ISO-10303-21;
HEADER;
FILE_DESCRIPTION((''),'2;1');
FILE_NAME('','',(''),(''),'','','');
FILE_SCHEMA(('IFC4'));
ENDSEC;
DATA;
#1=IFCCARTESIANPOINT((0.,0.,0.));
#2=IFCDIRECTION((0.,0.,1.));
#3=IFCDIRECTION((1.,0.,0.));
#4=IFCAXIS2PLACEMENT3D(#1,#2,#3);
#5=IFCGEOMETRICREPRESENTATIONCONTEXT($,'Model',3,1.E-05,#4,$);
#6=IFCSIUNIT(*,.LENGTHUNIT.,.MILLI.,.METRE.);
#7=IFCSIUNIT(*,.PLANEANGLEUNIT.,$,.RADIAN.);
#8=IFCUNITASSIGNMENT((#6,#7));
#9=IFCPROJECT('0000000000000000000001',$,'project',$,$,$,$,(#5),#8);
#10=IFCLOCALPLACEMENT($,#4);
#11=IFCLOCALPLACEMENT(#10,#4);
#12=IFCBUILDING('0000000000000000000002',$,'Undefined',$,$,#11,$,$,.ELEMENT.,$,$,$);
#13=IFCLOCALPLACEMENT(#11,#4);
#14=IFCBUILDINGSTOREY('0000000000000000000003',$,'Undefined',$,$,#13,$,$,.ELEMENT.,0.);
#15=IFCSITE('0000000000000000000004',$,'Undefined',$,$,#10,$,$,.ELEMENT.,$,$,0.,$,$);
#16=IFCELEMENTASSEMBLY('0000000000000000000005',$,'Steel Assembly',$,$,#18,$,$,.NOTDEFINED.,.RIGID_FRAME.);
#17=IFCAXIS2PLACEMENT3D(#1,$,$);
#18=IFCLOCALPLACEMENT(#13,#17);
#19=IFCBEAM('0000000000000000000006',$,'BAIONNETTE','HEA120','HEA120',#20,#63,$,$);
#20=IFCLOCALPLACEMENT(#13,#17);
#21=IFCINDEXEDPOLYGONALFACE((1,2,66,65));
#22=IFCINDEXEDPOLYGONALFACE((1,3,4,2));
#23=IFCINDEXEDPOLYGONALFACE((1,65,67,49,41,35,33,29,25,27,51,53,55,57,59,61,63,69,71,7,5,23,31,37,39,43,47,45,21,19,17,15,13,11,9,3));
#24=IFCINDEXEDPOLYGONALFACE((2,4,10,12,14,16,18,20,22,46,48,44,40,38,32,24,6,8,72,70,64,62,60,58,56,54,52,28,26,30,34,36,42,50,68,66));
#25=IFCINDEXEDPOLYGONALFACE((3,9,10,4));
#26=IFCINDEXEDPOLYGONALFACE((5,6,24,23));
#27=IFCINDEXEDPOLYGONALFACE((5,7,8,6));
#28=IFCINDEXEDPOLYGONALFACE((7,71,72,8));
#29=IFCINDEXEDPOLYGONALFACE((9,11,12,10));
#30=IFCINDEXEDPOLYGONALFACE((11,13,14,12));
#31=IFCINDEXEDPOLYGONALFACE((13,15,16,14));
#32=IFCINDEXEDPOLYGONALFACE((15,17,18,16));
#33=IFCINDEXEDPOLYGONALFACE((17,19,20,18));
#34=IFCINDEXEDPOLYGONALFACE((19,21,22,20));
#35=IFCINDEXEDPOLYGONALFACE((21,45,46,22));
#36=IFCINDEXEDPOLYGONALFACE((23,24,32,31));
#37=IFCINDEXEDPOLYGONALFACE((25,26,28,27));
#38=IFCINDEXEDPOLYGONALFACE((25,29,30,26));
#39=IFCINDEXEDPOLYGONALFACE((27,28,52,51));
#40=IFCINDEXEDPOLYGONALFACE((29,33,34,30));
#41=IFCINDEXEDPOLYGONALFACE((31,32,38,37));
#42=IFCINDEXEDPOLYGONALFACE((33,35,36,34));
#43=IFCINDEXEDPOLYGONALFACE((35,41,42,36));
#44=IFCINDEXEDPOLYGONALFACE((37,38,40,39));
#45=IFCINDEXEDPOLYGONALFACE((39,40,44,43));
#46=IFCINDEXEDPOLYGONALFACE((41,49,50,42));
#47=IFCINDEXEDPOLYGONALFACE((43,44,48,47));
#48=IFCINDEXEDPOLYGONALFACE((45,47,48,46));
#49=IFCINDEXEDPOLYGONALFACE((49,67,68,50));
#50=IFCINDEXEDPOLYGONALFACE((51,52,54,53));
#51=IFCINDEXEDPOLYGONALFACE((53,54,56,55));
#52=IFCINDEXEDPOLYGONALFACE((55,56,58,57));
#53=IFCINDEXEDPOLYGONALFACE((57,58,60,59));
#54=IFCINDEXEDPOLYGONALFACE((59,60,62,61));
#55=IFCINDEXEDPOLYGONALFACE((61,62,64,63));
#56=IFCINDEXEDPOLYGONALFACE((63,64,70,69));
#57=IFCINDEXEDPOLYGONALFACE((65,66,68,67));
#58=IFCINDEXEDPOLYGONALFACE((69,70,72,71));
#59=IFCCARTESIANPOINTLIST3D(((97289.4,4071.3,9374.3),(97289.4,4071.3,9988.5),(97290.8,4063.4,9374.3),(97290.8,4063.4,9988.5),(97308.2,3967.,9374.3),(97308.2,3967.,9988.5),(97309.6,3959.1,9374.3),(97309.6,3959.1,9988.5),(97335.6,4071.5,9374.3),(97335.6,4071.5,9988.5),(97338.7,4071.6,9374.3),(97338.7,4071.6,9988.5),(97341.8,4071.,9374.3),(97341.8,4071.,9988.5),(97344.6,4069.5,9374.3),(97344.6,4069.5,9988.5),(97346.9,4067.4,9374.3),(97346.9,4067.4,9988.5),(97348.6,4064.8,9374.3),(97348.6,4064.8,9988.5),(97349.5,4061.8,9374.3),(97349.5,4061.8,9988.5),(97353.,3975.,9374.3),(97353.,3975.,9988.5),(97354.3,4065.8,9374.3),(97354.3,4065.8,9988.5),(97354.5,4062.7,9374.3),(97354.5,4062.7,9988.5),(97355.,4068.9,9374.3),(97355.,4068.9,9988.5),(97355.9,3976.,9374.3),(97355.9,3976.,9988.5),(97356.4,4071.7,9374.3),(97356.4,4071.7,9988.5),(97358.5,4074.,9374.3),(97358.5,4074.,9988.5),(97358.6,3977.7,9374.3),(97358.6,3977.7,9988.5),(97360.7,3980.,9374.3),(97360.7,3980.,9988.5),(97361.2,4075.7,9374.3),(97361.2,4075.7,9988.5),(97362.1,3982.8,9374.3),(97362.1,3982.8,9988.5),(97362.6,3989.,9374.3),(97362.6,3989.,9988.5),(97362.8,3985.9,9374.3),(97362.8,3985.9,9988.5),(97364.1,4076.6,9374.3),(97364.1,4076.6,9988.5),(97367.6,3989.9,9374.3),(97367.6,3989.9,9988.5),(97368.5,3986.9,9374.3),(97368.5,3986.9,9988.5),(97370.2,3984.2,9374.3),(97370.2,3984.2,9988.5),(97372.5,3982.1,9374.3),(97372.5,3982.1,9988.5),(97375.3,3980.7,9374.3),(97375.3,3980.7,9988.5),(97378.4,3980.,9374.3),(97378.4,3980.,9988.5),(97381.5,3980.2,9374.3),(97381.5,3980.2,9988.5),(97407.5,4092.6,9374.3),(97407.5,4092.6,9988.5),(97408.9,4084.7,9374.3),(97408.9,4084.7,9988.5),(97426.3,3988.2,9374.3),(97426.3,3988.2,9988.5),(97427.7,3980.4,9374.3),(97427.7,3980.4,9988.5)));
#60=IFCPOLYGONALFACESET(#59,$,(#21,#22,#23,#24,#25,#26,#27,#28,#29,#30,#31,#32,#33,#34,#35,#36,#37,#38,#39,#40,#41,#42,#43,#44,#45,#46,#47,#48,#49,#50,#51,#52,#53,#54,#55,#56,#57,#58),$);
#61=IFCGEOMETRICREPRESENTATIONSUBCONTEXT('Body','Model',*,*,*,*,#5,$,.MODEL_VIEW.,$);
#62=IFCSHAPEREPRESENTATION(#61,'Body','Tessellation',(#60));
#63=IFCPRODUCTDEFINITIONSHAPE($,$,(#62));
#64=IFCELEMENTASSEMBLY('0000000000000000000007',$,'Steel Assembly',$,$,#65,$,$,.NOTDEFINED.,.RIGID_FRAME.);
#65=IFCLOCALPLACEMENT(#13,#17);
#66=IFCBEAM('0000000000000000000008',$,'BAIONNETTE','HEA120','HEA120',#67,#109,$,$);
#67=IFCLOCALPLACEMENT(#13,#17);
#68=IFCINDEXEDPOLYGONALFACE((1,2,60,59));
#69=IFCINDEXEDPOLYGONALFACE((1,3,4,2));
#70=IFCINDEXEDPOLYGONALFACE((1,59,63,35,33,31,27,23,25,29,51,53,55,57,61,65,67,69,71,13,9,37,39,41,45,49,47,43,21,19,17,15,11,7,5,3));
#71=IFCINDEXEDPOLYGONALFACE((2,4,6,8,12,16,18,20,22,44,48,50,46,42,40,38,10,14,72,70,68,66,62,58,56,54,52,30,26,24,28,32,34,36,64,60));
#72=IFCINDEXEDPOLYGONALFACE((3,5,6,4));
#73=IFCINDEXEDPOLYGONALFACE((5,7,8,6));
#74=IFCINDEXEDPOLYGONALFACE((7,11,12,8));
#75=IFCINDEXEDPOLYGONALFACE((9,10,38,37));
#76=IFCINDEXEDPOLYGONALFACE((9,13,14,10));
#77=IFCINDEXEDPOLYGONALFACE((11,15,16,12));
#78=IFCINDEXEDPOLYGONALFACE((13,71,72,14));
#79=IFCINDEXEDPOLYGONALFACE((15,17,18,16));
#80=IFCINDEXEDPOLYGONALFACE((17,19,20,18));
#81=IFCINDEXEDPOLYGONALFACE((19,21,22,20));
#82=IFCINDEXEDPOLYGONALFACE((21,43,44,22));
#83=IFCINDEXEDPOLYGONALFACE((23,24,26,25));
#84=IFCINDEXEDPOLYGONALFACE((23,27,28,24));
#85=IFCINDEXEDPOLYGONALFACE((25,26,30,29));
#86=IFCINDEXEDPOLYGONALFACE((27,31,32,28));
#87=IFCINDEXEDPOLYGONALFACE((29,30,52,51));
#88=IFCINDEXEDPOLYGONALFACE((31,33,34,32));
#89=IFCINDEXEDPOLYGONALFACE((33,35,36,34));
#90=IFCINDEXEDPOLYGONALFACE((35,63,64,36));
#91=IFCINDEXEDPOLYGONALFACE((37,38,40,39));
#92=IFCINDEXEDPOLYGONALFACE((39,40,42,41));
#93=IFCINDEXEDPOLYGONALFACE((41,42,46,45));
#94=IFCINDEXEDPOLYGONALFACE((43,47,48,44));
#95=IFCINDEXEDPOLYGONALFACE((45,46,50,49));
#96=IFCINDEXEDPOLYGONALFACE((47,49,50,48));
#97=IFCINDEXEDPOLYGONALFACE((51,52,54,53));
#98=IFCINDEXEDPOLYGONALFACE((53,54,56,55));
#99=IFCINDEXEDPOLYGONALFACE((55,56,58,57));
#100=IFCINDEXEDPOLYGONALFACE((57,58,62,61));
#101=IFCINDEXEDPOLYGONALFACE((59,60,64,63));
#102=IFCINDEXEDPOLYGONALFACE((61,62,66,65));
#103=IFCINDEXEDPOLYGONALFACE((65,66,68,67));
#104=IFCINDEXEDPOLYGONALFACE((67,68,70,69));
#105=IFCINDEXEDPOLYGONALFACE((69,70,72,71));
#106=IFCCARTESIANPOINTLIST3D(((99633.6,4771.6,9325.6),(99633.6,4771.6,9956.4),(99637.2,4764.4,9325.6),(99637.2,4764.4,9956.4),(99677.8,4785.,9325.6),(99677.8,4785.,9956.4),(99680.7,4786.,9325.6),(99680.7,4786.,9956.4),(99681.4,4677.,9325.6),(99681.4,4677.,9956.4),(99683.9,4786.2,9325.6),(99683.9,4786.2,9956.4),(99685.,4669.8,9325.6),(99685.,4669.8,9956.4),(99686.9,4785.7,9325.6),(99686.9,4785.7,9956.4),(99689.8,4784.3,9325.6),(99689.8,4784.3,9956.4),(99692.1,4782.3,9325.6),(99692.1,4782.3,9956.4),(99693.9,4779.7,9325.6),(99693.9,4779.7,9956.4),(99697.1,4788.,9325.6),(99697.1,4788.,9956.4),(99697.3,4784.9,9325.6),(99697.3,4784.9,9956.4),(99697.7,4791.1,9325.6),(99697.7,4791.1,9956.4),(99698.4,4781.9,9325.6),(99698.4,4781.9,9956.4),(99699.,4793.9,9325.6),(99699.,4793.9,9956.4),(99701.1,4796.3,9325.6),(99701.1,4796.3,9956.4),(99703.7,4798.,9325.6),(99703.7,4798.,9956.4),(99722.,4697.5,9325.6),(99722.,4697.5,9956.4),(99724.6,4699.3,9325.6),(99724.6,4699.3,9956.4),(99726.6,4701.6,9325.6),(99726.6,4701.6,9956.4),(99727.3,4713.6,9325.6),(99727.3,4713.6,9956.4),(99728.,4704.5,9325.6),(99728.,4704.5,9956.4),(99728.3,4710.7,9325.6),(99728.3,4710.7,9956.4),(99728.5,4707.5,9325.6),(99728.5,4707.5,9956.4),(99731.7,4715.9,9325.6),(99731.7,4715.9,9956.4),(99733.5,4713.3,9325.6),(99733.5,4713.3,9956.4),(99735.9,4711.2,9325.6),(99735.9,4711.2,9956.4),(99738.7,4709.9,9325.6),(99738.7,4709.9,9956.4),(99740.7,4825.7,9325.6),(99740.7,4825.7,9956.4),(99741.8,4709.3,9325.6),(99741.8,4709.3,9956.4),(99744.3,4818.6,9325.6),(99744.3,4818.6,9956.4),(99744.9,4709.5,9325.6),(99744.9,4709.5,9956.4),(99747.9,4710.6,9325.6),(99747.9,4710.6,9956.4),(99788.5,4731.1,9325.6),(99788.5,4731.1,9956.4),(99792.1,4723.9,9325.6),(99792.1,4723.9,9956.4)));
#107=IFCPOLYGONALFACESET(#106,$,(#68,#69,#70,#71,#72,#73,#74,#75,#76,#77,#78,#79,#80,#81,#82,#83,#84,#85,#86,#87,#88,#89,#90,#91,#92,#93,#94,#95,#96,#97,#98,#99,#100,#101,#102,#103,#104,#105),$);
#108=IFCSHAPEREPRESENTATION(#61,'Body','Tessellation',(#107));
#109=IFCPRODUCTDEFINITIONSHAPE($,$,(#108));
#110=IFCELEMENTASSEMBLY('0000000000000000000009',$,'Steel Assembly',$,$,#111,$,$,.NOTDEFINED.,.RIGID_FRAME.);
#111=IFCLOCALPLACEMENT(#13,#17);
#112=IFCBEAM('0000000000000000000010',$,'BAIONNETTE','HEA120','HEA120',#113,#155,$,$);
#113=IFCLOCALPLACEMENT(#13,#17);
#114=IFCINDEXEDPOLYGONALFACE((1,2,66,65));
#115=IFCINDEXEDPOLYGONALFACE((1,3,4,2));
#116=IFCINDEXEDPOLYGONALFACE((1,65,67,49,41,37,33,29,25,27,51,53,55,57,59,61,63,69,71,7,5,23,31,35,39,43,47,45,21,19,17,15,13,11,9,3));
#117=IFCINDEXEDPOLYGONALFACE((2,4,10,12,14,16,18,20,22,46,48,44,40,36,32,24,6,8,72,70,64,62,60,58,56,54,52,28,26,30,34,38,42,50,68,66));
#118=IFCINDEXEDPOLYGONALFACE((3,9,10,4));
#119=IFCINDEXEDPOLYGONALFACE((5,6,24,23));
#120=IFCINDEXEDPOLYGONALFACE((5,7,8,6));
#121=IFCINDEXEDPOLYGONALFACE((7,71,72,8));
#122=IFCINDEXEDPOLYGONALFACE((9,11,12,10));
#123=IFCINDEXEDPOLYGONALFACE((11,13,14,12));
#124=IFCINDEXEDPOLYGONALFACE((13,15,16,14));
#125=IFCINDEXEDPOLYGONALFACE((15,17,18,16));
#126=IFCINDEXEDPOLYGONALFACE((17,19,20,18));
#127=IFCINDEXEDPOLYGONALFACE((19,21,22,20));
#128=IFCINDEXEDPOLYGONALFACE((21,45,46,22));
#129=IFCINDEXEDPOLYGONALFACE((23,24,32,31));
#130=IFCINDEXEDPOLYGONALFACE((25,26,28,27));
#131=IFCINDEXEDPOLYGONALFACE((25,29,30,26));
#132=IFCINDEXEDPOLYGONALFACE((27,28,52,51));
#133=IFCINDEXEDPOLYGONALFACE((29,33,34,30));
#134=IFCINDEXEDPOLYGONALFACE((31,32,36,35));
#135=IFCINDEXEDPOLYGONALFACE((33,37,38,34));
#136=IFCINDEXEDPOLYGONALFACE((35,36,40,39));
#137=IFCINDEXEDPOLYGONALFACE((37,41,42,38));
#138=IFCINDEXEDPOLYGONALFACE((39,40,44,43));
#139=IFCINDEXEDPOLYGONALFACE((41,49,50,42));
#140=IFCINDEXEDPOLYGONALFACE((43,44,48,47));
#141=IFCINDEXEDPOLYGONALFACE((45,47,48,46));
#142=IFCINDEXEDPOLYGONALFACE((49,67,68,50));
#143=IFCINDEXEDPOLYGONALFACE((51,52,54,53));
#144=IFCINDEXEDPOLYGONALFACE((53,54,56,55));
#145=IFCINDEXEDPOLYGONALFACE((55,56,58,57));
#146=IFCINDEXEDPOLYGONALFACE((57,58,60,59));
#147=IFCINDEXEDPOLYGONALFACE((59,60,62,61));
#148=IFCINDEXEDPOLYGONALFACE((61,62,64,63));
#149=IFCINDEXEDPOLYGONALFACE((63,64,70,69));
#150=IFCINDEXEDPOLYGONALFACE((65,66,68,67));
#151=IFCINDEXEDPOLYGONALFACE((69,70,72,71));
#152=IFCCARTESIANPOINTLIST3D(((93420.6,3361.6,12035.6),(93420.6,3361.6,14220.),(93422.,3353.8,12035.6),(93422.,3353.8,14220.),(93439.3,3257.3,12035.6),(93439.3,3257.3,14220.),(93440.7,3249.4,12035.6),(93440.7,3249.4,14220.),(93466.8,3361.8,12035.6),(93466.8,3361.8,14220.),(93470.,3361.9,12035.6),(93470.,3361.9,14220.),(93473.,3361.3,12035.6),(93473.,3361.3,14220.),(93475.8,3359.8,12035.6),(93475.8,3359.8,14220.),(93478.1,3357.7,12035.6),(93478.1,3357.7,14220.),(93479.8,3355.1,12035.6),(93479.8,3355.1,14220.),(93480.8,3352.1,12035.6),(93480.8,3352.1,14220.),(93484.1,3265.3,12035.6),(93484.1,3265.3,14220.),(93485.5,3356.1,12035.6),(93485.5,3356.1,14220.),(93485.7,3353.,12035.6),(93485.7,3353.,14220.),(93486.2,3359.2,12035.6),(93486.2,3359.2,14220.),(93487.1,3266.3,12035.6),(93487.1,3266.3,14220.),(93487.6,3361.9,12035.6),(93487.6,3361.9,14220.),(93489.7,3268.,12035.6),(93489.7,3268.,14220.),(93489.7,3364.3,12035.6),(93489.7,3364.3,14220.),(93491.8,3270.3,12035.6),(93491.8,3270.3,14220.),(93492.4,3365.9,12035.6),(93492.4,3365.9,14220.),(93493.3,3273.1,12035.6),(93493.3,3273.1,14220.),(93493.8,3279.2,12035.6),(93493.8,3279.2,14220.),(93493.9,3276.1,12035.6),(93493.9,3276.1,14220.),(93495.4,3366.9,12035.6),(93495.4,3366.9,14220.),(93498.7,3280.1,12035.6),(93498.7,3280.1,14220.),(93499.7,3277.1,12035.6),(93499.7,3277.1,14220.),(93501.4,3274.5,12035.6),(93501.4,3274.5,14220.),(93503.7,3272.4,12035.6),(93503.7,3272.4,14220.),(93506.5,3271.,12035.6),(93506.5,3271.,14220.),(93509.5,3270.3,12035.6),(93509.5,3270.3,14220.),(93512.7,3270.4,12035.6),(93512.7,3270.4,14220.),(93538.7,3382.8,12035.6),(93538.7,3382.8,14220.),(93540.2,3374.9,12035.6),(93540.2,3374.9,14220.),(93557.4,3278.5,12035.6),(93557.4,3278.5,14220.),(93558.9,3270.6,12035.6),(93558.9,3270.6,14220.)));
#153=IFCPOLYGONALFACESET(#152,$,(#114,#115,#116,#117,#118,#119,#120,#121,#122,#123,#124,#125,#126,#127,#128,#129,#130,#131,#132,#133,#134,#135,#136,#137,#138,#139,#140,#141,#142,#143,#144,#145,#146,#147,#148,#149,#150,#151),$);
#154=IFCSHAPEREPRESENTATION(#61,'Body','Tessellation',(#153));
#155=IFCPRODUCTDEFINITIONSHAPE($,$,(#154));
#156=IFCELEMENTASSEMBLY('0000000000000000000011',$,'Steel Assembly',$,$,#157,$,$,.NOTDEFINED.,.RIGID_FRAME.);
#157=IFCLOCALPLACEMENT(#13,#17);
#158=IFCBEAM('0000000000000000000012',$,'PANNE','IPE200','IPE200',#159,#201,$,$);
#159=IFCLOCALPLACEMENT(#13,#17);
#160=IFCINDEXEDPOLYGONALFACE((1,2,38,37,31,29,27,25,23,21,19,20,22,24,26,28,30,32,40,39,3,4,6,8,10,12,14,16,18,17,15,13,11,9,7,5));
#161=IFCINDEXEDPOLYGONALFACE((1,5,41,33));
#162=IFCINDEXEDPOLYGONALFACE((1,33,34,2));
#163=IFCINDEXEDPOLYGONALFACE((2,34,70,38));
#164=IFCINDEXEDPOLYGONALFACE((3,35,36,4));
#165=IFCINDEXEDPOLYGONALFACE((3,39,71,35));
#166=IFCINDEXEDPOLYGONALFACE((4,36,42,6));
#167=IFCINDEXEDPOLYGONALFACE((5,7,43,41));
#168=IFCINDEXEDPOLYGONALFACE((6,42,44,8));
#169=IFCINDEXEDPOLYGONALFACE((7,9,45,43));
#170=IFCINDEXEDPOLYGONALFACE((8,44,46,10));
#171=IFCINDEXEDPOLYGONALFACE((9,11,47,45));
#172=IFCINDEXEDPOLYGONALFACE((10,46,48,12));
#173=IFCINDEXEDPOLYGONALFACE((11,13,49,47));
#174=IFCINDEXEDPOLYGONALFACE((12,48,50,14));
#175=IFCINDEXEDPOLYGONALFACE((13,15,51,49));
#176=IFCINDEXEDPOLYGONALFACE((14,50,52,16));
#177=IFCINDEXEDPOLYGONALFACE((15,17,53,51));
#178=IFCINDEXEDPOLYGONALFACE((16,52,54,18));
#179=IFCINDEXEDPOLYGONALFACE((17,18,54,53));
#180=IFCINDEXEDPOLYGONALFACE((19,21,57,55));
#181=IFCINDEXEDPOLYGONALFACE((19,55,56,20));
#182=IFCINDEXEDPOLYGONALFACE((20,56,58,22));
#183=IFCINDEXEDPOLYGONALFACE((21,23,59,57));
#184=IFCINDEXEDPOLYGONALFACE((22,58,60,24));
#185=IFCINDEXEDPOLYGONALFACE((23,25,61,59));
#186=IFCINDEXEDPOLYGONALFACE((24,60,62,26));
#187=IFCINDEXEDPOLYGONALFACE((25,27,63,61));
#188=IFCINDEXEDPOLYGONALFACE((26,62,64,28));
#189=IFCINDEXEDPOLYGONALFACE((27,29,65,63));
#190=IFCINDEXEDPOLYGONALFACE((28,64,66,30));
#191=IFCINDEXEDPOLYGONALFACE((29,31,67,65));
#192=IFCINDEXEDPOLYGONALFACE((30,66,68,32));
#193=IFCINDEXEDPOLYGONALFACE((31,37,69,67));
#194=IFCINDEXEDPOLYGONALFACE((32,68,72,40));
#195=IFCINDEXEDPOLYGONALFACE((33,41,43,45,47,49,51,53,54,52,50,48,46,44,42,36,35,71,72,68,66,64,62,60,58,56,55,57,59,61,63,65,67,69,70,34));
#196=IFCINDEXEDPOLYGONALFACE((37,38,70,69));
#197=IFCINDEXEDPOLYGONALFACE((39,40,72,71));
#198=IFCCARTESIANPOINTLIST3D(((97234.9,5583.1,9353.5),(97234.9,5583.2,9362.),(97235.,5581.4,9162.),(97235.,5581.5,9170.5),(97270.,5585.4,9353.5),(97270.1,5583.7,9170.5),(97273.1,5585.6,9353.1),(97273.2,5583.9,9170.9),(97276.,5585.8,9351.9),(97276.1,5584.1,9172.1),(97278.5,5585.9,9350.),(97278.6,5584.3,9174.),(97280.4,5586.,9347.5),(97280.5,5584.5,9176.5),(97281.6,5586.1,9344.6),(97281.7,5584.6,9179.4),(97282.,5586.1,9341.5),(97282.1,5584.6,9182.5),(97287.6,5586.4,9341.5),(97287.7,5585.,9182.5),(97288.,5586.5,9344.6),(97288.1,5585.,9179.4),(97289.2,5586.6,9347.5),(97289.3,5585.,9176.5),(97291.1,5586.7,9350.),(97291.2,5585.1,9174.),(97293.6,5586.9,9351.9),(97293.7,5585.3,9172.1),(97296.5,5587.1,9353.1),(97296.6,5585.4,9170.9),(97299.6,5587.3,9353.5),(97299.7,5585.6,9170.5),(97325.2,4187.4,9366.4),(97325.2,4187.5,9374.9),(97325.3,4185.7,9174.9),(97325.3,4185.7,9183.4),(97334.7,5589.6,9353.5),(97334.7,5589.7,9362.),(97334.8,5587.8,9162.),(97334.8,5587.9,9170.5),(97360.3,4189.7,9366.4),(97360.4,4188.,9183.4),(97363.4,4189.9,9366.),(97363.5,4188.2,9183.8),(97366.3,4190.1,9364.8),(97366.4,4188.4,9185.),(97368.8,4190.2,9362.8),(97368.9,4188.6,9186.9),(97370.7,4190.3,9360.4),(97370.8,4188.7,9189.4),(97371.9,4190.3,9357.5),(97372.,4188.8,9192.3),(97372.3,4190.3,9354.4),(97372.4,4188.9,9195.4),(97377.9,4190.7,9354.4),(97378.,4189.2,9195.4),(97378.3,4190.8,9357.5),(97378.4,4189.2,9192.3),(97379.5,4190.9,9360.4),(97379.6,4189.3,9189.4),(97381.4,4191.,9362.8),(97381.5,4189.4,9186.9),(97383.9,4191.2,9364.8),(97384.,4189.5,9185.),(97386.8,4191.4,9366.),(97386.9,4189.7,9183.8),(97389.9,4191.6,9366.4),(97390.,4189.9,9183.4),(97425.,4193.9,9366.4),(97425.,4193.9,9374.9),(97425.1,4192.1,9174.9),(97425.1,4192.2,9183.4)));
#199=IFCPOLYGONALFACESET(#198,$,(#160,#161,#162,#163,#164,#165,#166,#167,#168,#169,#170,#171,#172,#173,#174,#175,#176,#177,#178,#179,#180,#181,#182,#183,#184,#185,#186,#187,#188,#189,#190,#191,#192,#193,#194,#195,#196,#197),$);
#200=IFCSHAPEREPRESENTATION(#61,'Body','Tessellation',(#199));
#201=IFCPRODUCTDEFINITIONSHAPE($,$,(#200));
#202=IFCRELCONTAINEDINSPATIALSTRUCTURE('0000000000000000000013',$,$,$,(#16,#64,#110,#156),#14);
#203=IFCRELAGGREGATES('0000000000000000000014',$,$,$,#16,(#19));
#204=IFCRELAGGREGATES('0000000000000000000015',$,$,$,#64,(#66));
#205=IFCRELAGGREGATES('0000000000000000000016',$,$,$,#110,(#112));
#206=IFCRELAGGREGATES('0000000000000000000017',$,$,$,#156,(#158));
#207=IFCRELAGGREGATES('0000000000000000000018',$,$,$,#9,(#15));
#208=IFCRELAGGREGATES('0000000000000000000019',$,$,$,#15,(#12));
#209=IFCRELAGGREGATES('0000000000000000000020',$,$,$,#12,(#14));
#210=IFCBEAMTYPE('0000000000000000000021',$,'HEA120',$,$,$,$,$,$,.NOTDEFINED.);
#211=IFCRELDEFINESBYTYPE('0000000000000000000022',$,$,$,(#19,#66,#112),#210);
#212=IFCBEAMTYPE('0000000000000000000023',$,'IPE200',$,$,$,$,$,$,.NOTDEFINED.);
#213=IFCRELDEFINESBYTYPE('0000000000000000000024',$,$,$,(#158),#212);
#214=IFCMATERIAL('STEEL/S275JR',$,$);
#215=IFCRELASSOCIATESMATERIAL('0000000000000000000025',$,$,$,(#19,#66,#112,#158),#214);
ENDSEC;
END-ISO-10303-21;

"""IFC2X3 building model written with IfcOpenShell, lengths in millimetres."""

from ifc_helpers import new_model, si_unit, frame, origin_with_axes, origin_2d_with_axis, place, context, subcontext, project, spatial, i_section, extrude, material, type_object, element, aggregate, save


model = new_model("IFC2X3")

# Units and contexts
model_context = context("Model", 3, precision=1e-05, world=origin_with_axes())
body_context = subcontext(model_context, "Body", "Model", "MODEL_VIEW")
ifc_project = project(units=[si_unit("LENGTHUNIT", "METRE", prefix="MILLI"), si_unit("PLANEANGLEUNIT", "RADIAN")], contexts=[model_context])

# Site, building, storey
site_placement = place(None, origin_with_axes())
site = spatial("IfcSite", under=ifc_project, at=site_placement, Name="Undefined", CompositionType="ELEMENT", RefElevation=0.0)
building_placement = place(site_placement, origin_with_axes())
building = spatial("IfcBuilding", under=site, at=building_placement, Name="Undefined", CompositionType="ELEMENT")
storey_placement = place(building_placement, origin_with_axes())
storey = spatial("IfcBuildingStorey", under=building, at=storey_placement, Name="Undefined", CompositionType="ELEMENT", Elevation=0.0)

# Shared definitions
ifc_material = material(Name="STEEL/S275JR")

# Element assemblies, beams
assembly_1_placement = place(storey_placement, origin_with_axes())
assembly_1 = element("IfcElementAssembly", 1, at=assembly_1_placement, inside=storey, Name="Steel Assembly", AssemblyPlace="NOTDEFINED", PredefinedType="RIGID_FRAME")
beam_type_1 = type_object("IfcBeamType", Name="HEA120", PredefinedType="NOTDEFINED")
beam_1_placement = place(assembly_1_placement, frame((97358.5, 4025.8, 9988.5), z_axis=(-0.177139, 0.984186, 0.0), x_axis=(0.0, 0.0, -1.0)))
beam_1 = element("IfcBeam", 2, at=beam_1_placement, type_object=beam_type_1, material=ifc_material, Name="BAIONNETTE", Description="HEA120", ObjectType="HEA120", context=body_context, shape_type="SweptSolid", body=[
    extrude(i_section(OverallWidth=120.0, OverallDepth=114.0, WebThickness=5.0, FlangeThickness=8.0, FilletRadius=12.0, at=origin_2d_with_axis()), frame((614.2, 0.0, 0.0), z_axis=(-1.0, 0.0, 0.0), x_axis=(0.0, -1.0, 0.0)), (0.0, 0.0, 1.0), 614.2),
])
aggregate(assembly_1, [beam_1])
assembly_2_placement = place(storey_placement, origin_with_axes())
assembly_2 = element("IfcElementAssembly", 3, at=assembly_2_placement, inside=storey, Name="Steel Assembly", AssemblyPlace="NOTDEFINED", PredefinedType="RIGID_FRAME")
beam_2_placement = place(assembly_2_placement, frame((99712.8, 4747.8, 9956.5), z_axis=(-0.450873, 0.892588, 0.0), x_axis=(0.0, 0.0, -1.0)))
beam_2 = element("IfcBeam", 4, at=beam_2_placement, type_object=beam_type_1, material=ifc_material, Name="BAIONNETTE", Description="HEA120", ObjectType="HEA120", context=body_context, shape_type="SweptSolid", body=[
    extrude(i_section(OverallWidth=120.0, OverallDepth=114.0, WebThickness=5.0, FlangeThickness=8.0, FilletRadius=12.0, at=origin_2d_with_axis()), frame((630.8, 0.0, 0.0), z_axis=(-1.0, 0.0, 0.0), x_axis=(0.0, -1.0, 0.0)), (0.0, 0.0, 1.0), 630.8),
])
aggregate(assembly_2, [beam_2])
assembly_3_placement = place(storey_placement, origin_with_axes())
assembly_3 = element("IfcElementAssembly", 5, at=assembly_3_placement, inside=storey, Name="Steel Assembly", AssemblyPlace="NOTDEFINED", PredefinedType="RIGID_FRAME")
beam_3_placement = place(assembly_3_placement, frame((93489.7, 3316.1, 14220.0), z_axis=(-0.17637, 0.984324, 0.0), x_axis=(0.0, 0.0, -1.0)))
beam_3 = element("IfcBeam", 6, at=beam_3_placement, type_object=beam_type_1, material=ifc_material, Name="BAIONNETTE", Description="HEA120", ObjectType="HEA120", context=body_context, shape_type="SweptSolid", body=[
    extrude(i_section(OverallWidth=120.0, OverallDepth=114.0, WebThickness=5.0, FlangeThickness=8.0, FilletRadius=12.0, at=origin_2d_with_axis()), frame((2184.4, 0.0, 0.0), z_axis=(-1.0, 0.0, 0.0), x_axis=(0.0, -1.0, 0.0)), (0.0, 0.0, 1.0), 2184.4),
])
aggregate(assembly_3, [beam_3])
assembly_4_placement = place(storey_placement, origin_with_axes())
assembly_4 = element("IfcElementAssembly", 7, at=assembly_4_placement, inside=storey, Name="Steel Assembly", AssemblyPlace="NOTDEFINED", PredefinedType="RIGID_FRAME")
beam_type_2 = type_object("IfcBeamType", Name="IPE200", PredefinedType="NOTDEFINED")
beam_4_placement = place(assembly_4_placement, frame((97375.1, 4189.8, 9274.9), z_axis=(-0.000593, 0.009159, 0.999958), x_axis=(-0.064555, 0.997872, -0.009178)))
beam_4 = element("IfcBeam", 8, at=beam_4_placement, type_object=beam_type_2, material=ifc_material, Name="PANNE", Description="IPE200", ObjectType="IPE200", context=body_context, shape_type="SweptSolid", body=[
    extrude(i_section(OverallWidth=100.0, OverallDepth=200.0, WebThickness=5.6, FlangeThickness=8.5, FilletRadius=12.0, at=origin_2d_with_axis()), frame((1398.7, 0.0, 0.0), z_axis=(-1.0, 0.0, 0.0), x_axis=(0.0, -1.0, 0.0)), (0.0, 0.0, 1.0), 1398.7),
])
aggregate(assembly_4, [beam_4])

save(model, "model.ifc")
